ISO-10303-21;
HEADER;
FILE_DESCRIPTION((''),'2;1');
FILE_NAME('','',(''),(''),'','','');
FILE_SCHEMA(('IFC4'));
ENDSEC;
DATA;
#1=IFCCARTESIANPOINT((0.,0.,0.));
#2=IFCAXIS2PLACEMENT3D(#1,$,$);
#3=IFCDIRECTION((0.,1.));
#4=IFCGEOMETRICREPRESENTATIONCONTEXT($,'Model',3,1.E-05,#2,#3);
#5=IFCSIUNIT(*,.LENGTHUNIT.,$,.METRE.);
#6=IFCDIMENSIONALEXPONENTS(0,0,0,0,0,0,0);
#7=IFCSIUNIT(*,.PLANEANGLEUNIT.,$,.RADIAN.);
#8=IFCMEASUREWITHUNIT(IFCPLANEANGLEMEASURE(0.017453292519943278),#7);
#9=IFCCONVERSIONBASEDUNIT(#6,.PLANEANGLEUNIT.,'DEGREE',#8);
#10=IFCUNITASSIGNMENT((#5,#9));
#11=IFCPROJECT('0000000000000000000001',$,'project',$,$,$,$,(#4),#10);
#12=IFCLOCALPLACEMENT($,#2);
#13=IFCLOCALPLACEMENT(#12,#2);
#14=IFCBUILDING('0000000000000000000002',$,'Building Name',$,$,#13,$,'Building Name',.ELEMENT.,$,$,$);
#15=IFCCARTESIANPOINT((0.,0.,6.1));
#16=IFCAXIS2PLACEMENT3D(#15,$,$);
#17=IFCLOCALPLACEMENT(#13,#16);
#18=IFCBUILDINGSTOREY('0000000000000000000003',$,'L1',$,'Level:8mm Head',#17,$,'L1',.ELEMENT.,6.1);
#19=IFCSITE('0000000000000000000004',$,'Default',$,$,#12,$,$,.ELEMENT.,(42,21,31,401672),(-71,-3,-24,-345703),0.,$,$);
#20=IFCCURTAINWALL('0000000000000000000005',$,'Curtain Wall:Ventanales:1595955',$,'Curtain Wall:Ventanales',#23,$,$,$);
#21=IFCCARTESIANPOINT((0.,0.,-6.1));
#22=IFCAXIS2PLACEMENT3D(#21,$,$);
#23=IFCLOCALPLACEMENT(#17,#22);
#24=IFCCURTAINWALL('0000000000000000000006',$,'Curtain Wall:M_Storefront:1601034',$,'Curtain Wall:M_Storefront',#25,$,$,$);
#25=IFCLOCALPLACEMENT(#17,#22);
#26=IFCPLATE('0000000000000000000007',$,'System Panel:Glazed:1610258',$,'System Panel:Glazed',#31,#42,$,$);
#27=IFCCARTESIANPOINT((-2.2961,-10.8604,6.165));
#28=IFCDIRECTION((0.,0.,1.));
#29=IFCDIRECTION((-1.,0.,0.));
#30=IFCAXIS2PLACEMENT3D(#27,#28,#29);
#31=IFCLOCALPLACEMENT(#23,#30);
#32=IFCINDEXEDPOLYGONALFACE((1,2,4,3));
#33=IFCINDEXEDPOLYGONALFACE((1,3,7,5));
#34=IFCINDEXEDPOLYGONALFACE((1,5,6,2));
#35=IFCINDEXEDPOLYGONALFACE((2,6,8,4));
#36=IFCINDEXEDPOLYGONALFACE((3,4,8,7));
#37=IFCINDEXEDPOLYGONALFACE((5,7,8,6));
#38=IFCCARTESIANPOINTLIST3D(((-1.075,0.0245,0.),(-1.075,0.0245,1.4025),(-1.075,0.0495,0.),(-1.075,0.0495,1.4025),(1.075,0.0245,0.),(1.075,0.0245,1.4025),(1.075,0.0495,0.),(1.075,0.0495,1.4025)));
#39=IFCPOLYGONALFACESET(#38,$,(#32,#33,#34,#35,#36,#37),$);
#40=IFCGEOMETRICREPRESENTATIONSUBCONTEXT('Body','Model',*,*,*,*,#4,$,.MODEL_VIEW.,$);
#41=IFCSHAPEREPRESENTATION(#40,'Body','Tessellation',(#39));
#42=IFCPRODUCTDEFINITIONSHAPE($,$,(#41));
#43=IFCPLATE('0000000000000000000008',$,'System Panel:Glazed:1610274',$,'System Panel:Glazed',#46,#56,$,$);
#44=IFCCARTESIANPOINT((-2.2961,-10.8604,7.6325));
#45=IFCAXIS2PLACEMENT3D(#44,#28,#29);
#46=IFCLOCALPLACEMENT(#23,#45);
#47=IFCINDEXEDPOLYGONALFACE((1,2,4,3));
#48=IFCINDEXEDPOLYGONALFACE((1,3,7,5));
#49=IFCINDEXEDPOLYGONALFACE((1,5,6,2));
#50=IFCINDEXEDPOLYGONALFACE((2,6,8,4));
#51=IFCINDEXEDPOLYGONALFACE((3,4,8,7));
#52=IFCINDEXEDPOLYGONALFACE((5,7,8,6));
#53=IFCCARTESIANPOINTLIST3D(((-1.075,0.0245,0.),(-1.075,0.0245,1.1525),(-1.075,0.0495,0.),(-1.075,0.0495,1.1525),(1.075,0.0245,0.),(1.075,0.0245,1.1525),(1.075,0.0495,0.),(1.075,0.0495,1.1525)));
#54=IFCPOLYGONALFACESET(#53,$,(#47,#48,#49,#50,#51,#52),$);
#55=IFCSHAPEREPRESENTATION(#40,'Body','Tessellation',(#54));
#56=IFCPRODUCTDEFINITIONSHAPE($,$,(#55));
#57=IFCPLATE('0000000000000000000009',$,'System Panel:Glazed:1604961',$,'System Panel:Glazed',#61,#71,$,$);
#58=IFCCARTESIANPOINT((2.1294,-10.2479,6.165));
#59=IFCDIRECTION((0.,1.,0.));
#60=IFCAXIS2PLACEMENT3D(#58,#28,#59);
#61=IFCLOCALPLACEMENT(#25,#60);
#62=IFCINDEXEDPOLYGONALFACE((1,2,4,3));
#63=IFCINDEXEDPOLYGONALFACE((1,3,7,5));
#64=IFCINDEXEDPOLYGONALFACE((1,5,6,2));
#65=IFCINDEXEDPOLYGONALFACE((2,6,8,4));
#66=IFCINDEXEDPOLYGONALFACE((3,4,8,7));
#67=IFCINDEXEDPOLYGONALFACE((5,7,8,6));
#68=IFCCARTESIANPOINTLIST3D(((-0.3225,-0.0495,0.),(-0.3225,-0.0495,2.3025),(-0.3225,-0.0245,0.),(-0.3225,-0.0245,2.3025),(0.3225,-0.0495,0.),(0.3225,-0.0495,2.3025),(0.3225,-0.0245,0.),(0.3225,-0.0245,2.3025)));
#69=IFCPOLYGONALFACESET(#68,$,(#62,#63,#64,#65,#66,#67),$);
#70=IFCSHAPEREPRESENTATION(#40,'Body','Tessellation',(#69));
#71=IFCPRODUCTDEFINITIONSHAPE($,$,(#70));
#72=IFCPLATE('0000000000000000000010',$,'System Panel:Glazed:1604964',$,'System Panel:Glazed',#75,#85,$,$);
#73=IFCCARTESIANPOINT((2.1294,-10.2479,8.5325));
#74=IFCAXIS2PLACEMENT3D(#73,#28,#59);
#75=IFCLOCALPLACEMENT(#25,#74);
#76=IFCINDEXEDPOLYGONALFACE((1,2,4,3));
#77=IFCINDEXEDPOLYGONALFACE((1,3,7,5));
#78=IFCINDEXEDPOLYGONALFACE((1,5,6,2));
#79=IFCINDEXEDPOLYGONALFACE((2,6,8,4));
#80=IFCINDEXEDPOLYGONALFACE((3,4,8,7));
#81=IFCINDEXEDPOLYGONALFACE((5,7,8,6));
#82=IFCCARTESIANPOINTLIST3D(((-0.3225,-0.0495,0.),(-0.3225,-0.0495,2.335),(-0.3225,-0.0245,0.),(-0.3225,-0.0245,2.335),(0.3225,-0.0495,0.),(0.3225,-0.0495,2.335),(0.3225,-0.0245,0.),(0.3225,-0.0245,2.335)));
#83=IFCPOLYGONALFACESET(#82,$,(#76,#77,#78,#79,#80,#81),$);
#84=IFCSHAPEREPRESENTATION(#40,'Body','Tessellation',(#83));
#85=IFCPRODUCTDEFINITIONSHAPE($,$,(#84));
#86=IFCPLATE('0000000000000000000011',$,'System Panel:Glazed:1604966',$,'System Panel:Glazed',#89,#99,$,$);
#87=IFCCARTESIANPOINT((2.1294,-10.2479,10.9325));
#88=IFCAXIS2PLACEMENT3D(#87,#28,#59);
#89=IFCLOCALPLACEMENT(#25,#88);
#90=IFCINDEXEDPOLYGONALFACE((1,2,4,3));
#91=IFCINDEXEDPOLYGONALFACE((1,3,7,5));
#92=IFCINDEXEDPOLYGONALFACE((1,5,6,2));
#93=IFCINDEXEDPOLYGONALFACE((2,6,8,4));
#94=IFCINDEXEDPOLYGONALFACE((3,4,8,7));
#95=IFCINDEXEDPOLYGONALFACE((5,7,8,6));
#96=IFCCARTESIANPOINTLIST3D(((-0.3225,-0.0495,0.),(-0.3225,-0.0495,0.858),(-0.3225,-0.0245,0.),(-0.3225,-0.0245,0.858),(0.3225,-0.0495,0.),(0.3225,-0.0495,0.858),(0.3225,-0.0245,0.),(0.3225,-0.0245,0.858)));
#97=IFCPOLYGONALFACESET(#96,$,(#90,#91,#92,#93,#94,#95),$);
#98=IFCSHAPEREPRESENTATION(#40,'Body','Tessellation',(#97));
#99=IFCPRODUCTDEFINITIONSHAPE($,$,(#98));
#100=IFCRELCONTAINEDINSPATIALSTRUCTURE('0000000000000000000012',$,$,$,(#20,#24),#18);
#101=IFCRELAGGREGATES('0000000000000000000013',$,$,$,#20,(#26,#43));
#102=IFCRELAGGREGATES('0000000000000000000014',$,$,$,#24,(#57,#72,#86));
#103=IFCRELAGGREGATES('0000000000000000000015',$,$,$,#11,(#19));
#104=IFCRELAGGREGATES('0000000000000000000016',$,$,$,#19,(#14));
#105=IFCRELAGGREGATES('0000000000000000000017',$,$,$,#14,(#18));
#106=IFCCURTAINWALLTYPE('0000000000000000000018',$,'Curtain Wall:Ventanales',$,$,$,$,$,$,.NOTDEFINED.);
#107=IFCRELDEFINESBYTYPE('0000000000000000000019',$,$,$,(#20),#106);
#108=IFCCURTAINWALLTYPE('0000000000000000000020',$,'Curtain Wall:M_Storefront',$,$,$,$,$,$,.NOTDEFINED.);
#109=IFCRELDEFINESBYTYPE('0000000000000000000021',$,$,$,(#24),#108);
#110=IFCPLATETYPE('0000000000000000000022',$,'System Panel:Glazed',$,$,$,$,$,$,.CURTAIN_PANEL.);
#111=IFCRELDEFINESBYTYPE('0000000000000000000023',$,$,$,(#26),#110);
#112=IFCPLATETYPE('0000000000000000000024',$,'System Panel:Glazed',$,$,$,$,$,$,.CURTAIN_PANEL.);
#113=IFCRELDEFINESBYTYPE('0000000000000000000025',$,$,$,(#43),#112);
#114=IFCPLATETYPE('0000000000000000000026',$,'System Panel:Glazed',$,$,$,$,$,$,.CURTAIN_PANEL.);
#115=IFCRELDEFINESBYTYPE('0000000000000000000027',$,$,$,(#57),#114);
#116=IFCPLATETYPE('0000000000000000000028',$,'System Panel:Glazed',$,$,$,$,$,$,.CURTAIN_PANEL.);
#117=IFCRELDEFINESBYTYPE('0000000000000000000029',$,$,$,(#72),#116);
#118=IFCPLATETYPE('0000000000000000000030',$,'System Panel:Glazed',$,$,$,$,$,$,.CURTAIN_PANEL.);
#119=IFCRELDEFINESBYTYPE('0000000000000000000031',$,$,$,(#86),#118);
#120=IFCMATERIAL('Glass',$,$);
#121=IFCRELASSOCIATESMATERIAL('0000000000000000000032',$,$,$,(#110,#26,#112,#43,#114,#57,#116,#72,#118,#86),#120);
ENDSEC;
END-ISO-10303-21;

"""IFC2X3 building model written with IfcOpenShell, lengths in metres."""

from ifc_helpers import new_model, entity, si_unit, converted_unit, direction, frame, origin, origin_2d_with_axis, place, context, subcontext, project, spatial, rectangle, extrude, source, transform, mapped, material, type_object, type_shapes, element, aggregate, save


model = new_model("IFC2X3")

# Units and contexts
model_context = context("Model", 3, precision=1e-05, world=origin(), true_north=direction((0.0, 1.0)))
body_context = subcontext(model_context, "Body", "Model", "MODEL_VIEW")
ifc_project = project(units=[si_unit("LENGTHUNIT", "METRE"), converted_unit("PLANEANGLEUNIT", "DEGREE", entity("IfcPlaneAngleMeasure", 0.017453292519943278), si_unit("PLANEANGLEUNIT", "RADIAN"), dimensions=[0, 0, 0, 0, 0, 0, 0])], contexts=[model_context])

# Site, building, storey
site_placement = place(None, origin())
site = spatial("IfcSite", under=ifc_project, at=site_placement, Name="Default", CompositionType="ELEMENT", RefLatitude=(42, 21, 31, 401672), RefLongitude=(-71, -3, -24, -345703), RefElevation=0.0)
building_placement = place(site_placement, origin())
building = spatial("IfcBuilding", under=site, at=building_placement, Name="Building Name", LongName="Building Name", CompositionType="ELEMENT")
storey_placement = place(building_placement, frame((0.0, 0.0, 6.1)))
storey = spatial("IfcBuildingStorey", under=building, at=storey_placement, Name="L1", ObjectType="Level:8mm Head", LongName="L1", CompositionType="ELEMENT", Elevation=6.1)

# Curtain wall
curtain_wall_type_1 = type_object("IfcCurtainWallType", Name="Curtain Wall:Ventanales", PredefinedType="NOTDEFINED")
curtain_wall_1_placement = place(storey_placement, frame((0.0, 0.0, -6.1)))
curtain_wall_1 = element("IfcCurtainWall", 1, at=curtain_wall_1_placement, inside=storey, type_object=curtain_wall_type_1, Name="Curtain Wall:Ventanales:1595955", ObjectType="Curtain Wall:Ventanales")

# Curtain wall
curtain_wall_type_2 = type_object("IfcCurtainWallType", Name="Curtain Wall:M_Storefront", PredefinedType="NOTDEFINED")
curtain_wall_2_placement = place(storey_placement, frame((0.0, 0.0, -6.1)))
curtain_wall_2 = element("IfcCurtainWall", 2, at=curtain_wall_2_placement, inside=storey, type_object=curtain_wall_type_2, Name="Curtain Wall:M_Storefront:1601034", ObjectType="Curtain Wall:M_Storefront")

# Plates
ifc_material_1 = material(Name="Glass")
plate_type_1 = type_object("IfcPlateType", Name="System Panel:Glazed", PredefinedType="CURTAIN_PANEL", material=ifc_material_1)
shared_shape_1 = source(origin(), body_context, "Body", "SweptSolid", [
    extrude(rectangle(XDim=0.025, YDim=2.15, at=origin_2d_with_axis()), frame((0.0, 0.037, 0.0), z_axis=(0.0, 0.0, 1.0), x_axis=(0.0, 1.0, 0.0)), (0.0, 0.0, 1.0), 1.4025),
])
type_shapes(plate_type_1, [shared_shape_1])
plate_1_placement = place(curtain_wall_1_placement, frame((-2.2961, -10.8604, 6.165), z_axis=(0.0, 0.0, 1.0), x_axis=(-1.0, 0.0, 0.0)))
plate_1 = element("IfcPlate", 3, at=plate_1_placement, type_object=plate_type_1, material=ifc_material_1, Name="System Panel:Glazed:1610258", ObjectType="System Panel:Glazed", context=body_context, shape_type="MappedRepresentation", body=[
    mapped(shared_shape_1, transform((0.0, 0.0, 0.0), scale=1.0)),
])
plate_type_2 = type_object("IfcPlateType", Name="System Panel:Glazed", PredefinedType="CURTAIN_PANEL", material=ifc_material_1)
shared_shape_2 = source(origin(), body_context, "Body", "SweptSolid", [
    extrude(rectangle(XDim=0.025, YDim=2.15, at=origin_2d_with_axis()), frame((0.0, 0.037, 0.0), z_axis=(0.0, 0.0, 1.0), x_axis=(0.0, 1.0, 0.0)), (0.0, 0.0, 1.0), 1.1525),
])
type_shapes(plate_type_2, [shared_shape_2])
plate_2_placement = place(curtain_wall_1_placement, frame((-2.2961, -10.8604, 7.6325), z_axis=(0.0, 0.0, 1.0), x_axis=(-1.0, 0.0, 0.0)))
plate_2 = element("IfcPlate", 4, at=plate_2_placement, type_object=plate_type_2, material=ifc_material_1, Name="System Panel:Glazed:1610274", ObjectType="System Panel:Glazed", context=body_context, shape_type="MappedRepresentation", body=[
    mapped(shared_shape_2, transform((0.0, 0.0, 0.0), scale=1.0)),
])
aggregate(curtain_wall_1, [plate_1, plate_2])
plate_type_3 = type_object("IfcPlateType", Name="System Panel:Glazed", PredefinedType="CURTAIN_PANEL", material=ifc_material_1)
shared_shape_3 = source(origin(), body_context, "Body", "SweptSolid", [
    extrude(rectangle(XDim=0.025, YDim=0.645, at=origin_2d_with_axis()), frame((0.0, -0.037, 0.0), z_axis=(0.0, 0.0, 1.0), x_axis=(0.0, 1.0, 0.0)), (0.0, 0.0, 1.0), 2.3025),
])
type_shapes(plate_type_3, [shared_shape_3])
plate_3_placement = place(curtain_wall_2_placement, frame((2.1294, -10.2479, 6.165), z_axis=(0.0, 0.0, 1.0), x_axis=(0.0, 1.0, 0.0)))
plate_3 = element("IfcPlate", 5, at=plate_3_placement, type_object=plate_type_3, material=ifc_material_1, Name="System Panel:Glazed:1604961", ObjectType="System Panel:Glazed", context=body_context, shape_type="MappedRepresentation", body=[
    mapped(shared_shape_3, transform((0.0, 0.0, 0.0), scale=1.0)),
])
plate_type_4 = type_object("IfcPlateType", Name="System Panel:Glazed", PredefinedType="CURTAIN_PANEL", material=ifc_material_1)
shared_shape_4 = source(origin(), body_context, "Body", "SweptSolid", [
    extrude(rectangle(XDim=0.025, YDim=0.645, at=origin_2d_with_axis()), frame((0.0, -0.037, 0.0), z_axis=(0.0, 0.0, 1.0), x_axis=(0.0, 1.0, 0.0)), (0.0, 0.0, 1.0), 2.335),
])
type_shapes(plate_type_4, [shared_shape_4])
plate_4_placement = place(curtain_wall_2_placement, frame((2.1294, -10.2479, 8.5325), z_axis=(0.0, 0.0, 1.0), x_axis=(0.0, 1.0, 0.0)))
plate_4 = element("IfcPlate", 6, at=plate_4_placement, type_object=plate_type_4, material=ifc_material_1, Name="System Panel:Glazed:1604964", ObjectType="System Panel:Glazed", context=body_context, shape_type="MappedRepresentation", body=[
    mapped(shared_shape_4, transform((0.0, 0.0, 0.0), scale=1.0)),
])
plate_type_5 = type_object("IfcPlateType", Name="System Panel:Glazed", PredefinedType="CURTAIN_PANEL", material=ifc_material_1)
shared_shape_5 = source(origin(), body_context, "Body", "SweptSolid", [
    extrude(rectangle(XDim=0.025, YDim=0.645, at=origin_2d_with_axis()), frame((0.0, -0.037, 0.0), z_axis=(0.0, 0.0, 1.0), x_axis=(0.0, 1.0, 0.0)), (0.0, 0.0, 1.0), 0.858),
])
type_shapes(plate_type_5, [shared_shape_5])
plate_5_placement = place(curtain_wall_2_placement, frame((2.1294, -10.2479, 10.9325), z_axis=(0.0, 0.0, 1.0), x_axis=(0.0, 1.0, 0.0)))
plate_5 = element("IfcPlate", 7, at=plate_5_placement, type_object=plate_type_5, material=ifc_material_1, Name="System Panel:Glazed:1604966", ObjectType="System Panel:Glazed", context=body_context, shape_type="MappedRepresentation", body=[
    mapped(shared_shape_5, transform((0.0, 0.0, 0.0), scale=1.0)),
])
aggregate(curtain_wall_2, [plate_3, plate_4, plate_5])

save(model, "model.ifc")
